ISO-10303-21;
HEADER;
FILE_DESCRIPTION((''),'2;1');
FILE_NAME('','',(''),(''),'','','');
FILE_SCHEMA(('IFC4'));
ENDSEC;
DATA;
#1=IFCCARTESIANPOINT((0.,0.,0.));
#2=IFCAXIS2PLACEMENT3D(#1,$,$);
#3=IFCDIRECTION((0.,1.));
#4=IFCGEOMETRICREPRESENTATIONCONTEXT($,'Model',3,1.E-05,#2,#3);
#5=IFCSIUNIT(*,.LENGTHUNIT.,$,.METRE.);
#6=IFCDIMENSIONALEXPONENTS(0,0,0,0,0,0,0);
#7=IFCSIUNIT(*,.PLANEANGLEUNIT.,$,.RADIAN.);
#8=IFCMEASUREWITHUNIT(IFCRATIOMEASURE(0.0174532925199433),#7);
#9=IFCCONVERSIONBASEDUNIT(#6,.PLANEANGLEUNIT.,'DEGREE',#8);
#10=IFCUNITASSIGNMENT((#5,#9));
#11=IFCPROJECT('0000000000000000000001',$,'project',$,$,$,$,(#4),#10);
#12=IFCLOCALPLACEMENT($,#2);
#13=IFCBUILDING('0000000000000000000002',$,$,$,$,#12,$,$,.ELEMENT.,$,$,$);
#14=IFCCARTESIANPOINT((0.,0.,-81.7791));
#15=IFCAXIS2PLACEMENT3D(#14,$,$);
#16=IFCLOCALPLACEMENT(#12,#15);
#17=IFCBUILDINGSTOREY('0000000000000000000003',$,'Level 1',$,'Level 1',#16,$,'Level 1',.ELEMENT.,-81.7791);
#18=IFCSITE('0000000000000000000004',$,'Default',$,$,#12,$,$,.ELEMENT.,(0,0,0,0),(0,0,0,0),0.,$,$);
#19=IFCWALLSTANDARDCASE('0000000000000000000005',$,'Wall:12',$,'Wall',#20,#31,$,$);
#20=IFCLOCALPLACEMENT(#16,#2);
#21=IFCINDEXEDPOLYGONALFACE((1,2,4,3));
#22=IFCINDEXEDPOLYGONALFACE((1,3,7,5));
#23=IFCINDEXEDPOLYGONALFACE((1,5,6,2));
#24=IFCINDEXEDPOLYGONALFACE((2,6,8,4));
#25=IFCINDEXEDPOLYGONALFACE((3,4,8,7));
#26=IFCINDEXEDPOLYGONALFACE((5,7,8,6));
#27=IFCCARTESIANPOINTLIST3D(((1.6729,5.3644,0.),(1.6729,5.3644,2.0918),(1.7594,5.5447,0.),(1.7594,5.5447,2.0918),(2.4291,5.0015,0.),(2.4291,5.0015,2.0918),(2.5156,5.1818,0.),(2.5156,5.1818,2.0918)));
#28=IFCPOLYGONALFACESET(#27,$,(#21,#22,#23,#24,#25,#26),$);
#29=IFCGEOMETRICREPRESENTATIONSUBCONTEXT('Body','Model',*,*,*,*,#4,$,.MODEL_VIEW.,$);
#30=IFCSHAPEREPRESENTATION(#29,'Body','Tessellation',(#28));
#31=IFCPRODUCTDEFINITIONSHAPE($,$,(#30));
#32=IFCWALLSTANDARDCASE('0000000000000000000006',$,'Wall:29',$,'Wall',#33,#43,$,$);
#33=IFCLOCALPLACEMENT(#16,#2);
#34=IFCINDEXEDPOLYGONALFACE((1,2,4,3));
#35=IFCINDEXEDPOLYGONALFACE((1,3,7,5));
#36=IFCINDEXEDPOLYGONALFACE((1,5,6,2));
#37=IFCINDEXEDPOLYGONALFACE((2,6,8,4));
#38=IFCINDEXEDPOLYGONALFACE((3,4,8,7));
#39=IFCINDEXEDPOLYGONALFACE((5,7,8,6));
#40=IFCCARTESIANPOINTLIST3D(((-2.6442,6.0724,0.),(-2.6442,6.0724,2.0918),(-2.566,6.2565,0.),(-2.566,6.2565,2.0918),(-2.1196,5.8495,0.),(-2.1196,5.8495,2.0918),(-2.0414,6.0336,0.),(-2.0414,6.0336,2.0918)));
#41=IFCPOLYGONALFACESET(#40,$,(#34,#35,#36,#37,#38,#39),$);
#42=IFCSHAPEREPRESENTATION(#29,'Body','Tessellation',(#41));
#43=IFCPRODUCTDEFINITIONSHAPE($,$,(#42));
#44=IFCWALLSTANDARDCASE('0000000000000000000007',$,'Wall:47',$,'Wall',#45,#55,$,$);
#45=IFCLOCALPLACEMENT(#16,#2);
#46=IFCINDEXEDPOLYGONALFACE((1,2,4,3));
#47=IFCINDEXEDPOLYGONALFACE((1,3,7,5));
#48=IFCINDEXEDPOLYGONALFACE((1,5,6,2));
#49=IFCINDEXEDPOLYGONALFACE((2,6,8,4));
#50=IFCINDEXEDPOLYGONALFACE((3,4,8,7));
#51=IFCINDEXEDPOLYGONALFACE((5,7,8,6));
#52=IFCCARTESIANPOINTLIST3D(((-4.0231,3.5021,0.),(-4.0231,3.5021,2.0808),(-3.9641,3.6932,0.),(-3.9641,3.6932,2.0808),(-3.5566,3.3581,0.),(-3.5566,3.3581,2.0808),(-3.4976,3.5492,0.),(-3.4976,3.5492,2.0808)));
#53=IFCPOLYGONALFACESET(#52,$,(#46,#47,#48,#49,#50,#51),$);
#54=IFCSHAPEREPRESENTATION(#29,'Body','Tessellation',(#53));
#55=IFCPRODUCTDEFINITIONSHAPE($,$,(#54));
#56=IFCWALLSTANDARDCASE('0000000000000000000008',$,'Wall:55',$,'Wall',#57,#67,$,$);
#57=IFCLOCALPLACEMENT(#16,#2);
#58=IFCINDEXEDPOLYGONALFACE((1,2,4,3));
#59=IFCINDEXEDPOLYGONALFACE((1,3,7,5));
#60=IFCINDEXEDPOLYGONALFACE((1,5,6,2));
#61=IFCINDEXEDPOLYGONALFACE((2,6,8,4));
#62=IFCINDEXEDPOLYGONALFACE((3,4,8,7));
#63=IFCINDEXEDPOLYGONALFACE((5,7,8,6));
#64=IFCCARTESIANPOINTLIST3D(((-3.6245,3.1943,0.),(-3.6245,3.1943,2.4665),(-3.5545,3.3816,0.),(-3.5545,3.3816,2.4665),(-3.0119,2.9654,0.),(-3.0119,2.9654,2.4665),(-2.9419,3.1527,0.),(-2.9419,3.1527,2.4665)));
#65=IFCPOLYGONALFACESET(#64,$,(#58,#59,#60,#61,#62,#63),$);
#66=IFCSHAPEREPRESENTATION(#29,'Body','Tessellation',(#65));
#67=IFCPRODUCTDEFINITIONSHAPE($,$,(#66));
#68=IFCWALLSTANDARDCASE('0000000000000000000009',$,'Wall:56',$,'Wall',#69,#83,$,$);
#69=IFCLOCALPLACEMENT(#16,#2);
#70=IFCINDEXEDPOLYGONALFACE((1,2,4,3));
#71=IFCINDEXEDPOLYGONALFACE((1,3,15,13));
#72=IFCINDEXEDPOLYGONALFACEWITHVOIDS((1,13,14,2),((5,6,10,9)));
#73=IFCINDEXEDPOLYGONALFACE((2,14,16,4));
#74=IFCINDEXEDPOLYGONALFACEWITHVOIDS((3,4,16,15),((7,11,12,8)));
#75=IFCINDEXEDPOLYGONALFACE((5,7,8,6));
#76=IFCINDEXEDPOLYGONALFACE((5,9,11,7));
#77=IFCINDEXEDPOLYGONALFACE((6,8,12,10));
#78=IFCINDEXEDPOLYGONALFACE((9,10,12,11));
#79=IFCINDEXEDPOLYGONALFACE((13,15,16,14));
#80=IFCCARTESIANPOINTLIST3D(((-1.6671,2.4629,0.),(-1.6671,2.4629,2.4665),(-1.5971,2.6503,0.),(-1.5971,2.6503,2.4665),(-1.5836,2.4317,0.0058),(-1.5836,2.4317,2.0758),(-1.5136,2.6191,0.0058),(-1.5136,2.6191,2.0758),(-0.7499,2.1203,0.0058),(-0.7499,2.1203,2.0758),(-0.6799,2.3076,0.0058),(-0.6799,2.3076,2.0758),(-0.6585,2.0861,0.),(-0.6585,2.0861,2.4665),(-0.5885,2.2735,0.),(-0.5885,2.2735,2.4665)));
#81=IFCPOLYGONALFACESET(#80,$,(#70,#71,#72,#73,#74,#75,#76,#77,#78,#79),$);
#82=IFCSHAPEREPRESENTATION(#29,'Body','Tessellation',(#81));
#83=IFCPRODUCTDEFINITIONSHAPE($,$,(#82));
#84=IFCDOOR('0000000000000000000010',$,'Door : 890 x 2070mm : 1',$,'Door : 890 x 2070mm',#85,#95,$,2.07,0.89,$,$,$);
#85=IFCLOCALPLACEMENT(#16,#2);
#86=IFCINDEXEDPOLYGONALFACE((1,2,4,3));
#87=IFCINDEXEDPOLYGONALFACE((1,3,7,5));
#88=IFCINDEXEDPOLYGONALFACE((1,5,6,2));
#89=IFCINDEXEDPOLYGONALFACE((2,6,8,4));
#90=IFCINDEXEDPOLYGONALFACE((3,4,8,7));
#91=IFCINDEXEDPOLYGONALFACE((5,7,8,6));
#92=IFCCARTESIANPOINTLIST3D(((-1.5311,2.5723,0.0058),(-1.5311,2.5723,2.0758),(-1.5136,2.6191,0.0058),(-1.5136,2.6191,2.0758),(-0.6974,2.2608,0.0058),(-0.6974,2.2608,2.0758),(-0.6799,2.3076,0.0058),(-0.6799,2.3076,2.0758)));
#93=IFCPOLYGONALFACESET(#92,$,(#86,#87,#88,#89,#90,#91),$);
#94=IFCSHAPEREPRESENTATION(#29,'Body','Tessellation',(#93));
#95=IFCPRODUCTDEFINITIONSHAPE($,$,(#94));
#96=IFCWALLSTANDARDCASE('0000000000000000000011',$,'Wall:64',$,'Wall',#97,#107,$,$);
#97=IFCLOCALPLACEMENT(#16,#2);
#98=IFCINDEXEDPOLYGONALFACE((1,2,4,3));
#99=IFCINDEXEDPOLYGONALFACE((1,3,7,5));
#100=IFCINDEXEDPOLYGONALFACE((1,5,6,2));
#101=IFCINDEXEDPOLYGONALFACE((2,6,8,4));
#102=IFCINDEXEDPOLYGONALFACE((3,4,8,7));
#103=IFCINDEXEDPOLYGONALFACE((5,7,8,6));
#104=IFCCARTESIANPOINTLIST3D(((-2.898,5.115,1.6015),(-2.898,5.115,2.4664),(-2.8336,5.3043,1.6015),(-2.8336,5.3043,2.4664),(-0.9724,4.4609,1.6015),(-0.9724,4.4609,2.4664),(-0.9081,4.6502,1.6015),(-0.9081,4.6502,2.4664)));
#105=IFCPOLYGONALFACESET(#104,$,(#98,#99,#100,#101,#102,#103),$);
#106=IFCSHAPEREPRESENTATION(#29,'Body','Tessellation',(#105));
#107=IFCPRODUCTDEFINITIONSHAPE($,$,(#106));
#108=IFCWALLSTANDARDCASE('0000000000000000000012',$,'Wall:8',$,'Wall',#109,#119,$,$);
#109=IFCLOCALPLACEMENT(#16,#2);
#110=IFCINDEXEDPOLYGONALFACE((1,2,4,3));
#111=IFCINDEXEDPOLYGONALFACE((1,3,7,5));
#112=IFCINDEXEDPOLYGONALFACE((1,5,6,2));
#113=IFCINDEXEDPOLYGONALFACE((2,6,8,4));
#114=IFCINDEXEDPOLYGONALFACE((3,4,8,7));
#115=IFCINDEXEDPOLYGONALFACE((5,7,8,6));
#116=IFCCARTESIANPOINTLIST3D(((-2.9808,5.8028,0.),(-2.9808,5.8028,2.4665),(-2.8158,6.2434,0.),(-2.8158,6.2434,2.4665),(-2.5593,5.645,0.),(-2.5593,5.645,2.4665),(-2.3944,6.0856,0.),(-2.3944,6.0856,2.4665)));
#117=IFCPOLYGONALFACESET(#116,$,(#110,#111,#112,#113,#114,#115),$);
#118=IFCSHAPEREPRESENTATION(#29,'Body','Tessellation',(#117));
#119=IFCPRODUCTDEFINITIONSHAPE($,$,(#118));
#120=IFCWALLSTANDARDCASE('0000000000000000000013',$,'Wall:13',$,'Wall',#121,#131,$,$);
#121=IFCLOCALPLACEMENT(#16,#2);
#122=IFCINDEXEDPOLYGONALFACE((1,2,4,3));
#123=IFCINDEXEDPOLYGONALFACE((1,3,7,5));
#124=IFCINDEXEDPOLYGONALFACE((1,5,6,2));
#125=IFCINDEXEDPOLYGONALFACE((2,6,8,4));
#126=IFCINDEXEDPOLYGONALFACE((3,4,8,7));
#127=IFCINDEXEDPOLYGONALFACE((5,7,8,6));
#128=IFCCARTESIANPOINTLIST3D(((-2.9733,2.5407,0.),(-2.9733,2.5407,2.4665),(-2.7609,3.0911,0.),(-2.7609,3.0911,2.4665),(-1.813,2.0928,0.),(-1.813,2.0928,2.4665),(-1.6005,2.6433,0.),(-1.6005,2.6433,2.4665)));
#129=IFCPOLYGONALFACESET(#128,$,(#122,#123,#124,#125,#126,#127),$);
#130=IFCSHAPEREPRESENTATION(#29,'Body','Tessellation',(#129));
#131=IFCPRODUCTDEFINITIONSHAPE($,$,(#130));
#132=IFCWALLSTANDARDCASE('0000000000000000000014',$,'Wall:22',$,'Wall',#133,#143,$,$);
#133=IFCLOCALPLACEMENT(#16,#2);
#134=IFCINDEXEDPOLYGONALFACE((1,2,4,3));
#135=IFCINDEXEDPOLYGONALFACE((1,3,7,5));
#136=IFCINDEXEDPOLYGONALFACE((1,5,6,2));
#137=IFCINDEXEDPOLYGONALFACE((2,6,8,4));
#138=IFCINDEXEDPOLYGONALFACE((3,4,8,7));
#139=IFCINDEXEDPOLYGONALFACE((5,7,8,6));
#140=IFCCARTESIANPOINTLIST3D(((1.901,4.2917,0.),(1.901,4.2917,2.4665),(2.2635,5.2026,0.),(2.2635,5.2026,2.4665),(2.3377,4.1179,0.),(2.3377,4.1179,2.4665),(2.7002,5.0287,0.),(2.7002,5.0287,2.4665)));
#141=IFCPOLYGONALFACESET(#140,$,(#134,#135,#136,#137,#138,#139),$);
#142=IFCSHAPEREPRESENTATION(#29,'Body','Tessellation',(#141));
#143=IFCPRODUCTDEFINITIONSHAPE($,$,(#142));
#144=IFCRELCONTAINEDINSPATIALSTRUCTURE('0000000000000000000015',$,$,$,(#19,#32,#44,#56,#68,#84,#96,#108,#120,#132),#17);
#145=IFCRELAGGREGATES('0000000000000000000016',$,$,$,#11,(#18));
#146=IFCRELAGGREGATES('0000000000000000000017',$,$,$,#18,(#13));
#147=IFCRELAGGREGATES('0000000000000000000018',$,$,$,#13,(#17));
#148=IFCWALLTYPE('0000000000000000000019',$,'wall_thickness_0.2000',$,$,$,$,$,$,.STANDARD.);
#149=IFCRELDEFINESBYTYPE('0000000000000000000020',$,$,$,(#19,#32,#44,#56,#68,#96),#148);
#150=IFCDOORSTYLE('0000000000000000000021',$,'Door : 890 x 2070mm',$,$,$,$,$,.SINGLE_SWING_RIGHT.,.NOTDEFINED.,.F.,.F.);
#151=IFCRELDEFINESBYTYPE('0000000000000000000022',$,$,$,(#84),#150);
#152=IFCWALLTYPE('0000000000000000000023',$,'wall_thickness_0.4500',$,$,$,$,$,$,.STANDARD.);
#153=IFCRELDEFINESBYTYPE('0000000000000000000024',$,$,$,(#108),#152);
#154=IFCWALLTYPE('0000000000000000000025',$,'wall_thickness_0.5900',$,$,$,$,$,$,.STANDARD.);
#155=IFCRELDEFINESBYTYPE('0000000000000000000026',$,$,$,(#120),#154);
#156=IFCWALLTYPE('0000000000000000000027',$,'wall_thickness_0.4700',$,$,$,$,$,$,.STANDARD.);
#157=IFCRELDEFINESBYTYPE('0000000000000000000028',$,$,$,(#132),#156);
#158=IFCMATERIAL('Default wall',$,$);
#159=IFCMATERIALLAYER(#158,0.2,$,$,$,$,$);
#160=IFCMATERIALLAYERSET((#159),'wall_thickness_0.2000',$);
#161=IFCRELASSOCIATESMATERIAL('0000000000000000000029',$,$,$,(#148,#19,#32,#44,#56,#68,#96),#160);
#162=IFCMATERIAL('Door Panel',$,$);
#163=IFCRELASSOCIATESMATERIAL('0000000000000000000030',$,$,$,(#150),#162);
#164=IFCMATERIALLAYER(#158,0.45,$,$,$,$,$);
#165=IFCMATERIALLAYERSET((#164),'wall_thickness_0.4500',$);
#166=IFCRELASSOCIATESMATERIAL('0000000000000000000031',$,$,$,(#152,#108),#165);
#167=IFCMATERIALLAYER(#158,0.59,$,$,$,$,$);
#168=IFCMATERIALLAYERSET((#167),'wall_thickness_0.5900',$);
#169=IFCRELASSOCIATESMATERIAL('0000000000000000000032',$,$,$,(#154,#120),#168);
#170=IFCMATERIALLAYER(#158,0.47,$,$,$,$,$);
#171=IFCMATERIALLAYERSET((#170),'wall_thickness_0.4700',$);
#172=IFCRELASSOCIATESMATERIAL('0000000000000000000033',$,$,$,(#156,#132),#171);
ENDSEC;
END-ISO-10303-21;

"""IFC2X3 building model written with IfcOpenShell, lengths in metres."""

from ifc_helpers import new_model, entity, si_unit, converted_unit, direction, frame, frame_2d, origin, origin_2d_with_axis, place, context, subcontext, project, spatial, polyline, rectangle, outline, extrude, source, transform, mapped, material, layer, layer_set, layer_usage, type_object, type_shapes, element, fill, save


model = new_model("IFC2X3")

# Units and contexts
model_context = context("Model", 3, precision=1e-05, world=origin(), true_north=direction((0.0, 1.0)))
body_context = subcontext(model_context, "Body", "Model", "MODEL_VIEW")
ifc_project = project(units=[si_unit("LENGTHUNIT", "METRE"), converted_unit("PLANEANGLEUNIT", "DEGREE", entity("IfcRatioMeasure", 0.0174532925199433), si_unit("PLANEANGLEUNIT", "RADIAN"), dimensions=[0, 0, 0, 0, 0, 0, 0])], contexts=[model_context])

# Site, building, storey
placement_1 = place(None, origin())
site = spatial("IfcSite", under=ifc_project, at=placement_1, Name="Default", CompositionType="ELEMENT", RefLatitude=(0, 0, 0, 0), RefLongitude=(0, 0, 0, 0), RefElevation=0.0)
building = spatial("IfcBuilding", under=site, at=placement_1, CompositionType="ELEMENT")
storey_placement = place(placement_1, frame((0.0, 0.0, -81.7791)))
storey = spatial("IfcBuildingStorey", under=building, at=storey_placement, Name="Level 1", ObjectType="Level 1", LongName="Level 1", CompositionType="ELEMENT", Elevation=-81.7791)

# Walls
ifc_material_1 = material(Name="Default wall")
ifc_layer_1 = layer(ifc_material_1, 0.2)
ifc_layer_set_1 = layer_set([ifc_layer_1], Name="wall_thickness_0.2000")
ifc_layer_usage_1 = layer_usage(ifc_layer_set_1, "AXIS2", "POSITIVE", -0.1)
wall_type_1 = type_object("IfcWallType", Name="wall_thickness_0.2000", PredefinedType="STANDARD", material=ifc_layer_set_1)
wall_1_placement = place(storey_placement, frame((1.7162, 5.4546, 0.0), z_axis=(0.0, 0.0, 1.0), x_axis=(0.901567, -0.43264, 0.0)))
element("IfcWallStandardCase", 1, at=wall_1_placement, inside=storey, type_object=wall_type_1, material=ifc_layer_usage_1, Name="Wall:12", ObjectType="Wall", context=body_context, shape_type="SweptSolid", body=[
    extrude(outline(polyline([(0.8387, -0.1), (0.8387, 0.1), (0.0, 0.1), (0.0, -0.1), (0.8387, -0.1)])), origin(), (0.0, 0.0, 1.0), 2.0918),
])
wall_2_placement = place(storey_placement, frame((-2.6051, 6.1645, 0.0), z_axis=(0.0, 0.0, 1.0), x_axis=(0.920349, -0.391098, 0.0)))
element("IfcWallStandardCase", 2, at=wall_2_placement, inside=storey, type_object=wall_type_1, material=ifc_layer_usage_1, Name="Wall:29", ObjectType="Wall", context=body_context, shape_type="SweptSolid", body=[
    extrude(outline(polyline([(0.57, -0.1), (0.57, 0.1), (0.0, 0.1), (0.0, -0.1), (0.57, -0.1)])), origin(), (0.0, 0.0, 1.0), 2.0918),
])
wall_3_placement = place(storey_placement, frame((-3.9936, 3.5976, 0.0), z_axis=(0.0, 0.0, 1.0), x_axis=(0.955528, -0.2949, 0.0)))
element("IfcWallStandardCase", 3, at=wall_3_placement, inside=storey, type_object=wall_type_1, material=ifc_layer_usage_1, Name="Wall:47", ObjectType="Wall", context=body_context, shape_type="SweptSolid", body=[
    extrude(outline(polyline([(0.4882, -0.1), (0.4882, 0.1), (0.0, 0.1), (0.0, -0.1), (0.4882, -0.1)])), origin(), (0.0, 0.0, 1.0), 2.0808),
])
wall_4_placement = place(storey_placement, frame((-3.5895, 3.2879, 0.0), z_axis=(0.0, 0.0, 1.0), x_axis=(0.936753, -0.349992, 0.0)))
element("IfcWallStandardCase", 4, at=wall_4_placement, inside=storey, type_object=wall_type_1, material=ifc_layer_usage_1, Name="Wall:55", ObjectType="Wall", context=body_context, shape_type="SweptSolid", body=[
    extrude(outline(polyline([(0.654, -0.1), (0.654, 0.1), (0.0, 0.1), (0.0, -0.1), (0.654, -0.1)])), origin(), (0.0, 0.0, 1.0), 2.4665),
])

# Wall, opening, door
wall_5_placement = place(storey_placement, frame((-1.6321, 2.5566, 0.0), z_axis=(0.0, 0.0, 1.0), x_axis=(0.936753, -0.349992, 0.0)))
wall_5 = element("IfcWallStandardCase", 5, at=wall_5_placement, inside=storey, type_object=wall_type_1, material=ifc_layer_usage_1, Name="Wall:56", ObjectType="Wall", context=body_context, shape_type="SweptSolid", body=[
    extrude(outline(polyline([(1.0767, -0.1), (1.0767, 0.1), (0.0, 0.1), (0.0, -0.1), (1.0767, -0.1)])), origin(), (0.0, 0.0, 1.0), 2.4665),
])
opening_1_placement = place(wall_5_placement, frame((0.0891, -0.1, 0.0058)))
opening_1 = element("IfcOpeningElement", 6, at=opening_1_placement, cuts=wall_5, ObjectType="Opening", context=body_context, shape_type="SweptSolid", body=[
    extrude(rectangle(XDim=0.89, YDim=2.07, at=frame_2d((1.035, 0.445), x_axis=(0.0, 1.0))), frame((0.0, 0.0, 0.0), z_axis=(0.0, 1.0, 0.0), x_axis=(0.0, 0.0, 1.0)), (0.0, 0.0, 1.0), 0.2),
])
ifc_material_2 = material(Name="Door Panel")
door_style_1 = type_object("IfcDoorStyle", Name="Door : 890 x 2070mm", ConstructionType="NOTDEFINED", OperationType="SINGLE_SWING_RIGHT", ParameterTakesPrecedence=False, Sizeable=False, material=ifc_material_2)
shared_shape_1 = source(origin(), body_context, "Body", "SweptSolid", [
    extrude(rectangle(XDim=0.05, YDim=0.89, at=origin_2d_with_axis()), frame((0.445, 0.175, 0.0), z_axis=(0.0, 0.0, 1.0), x_axis=(0.0, 1.0, 0.0)), (0.0, 0.0, 1.0), 2.07),
])
type_shapes(door_style_1, [shared_shape_1])
door_1_placement = place(opening_1_placement, origin())
door_1 = element("IfcDoor", 7, at=door_1_placement, inside=storey, type_object=door_style_1, Name="Door : 890 x 2070mm : 1", ObjectType="Door : 890 x 2070mm", OverallHeight=2.07, OverallWidth=0.89, context=body_context, shape_type="MappedRepresentation", body=[
    mapped(shared_shape_1, transform((0.0, 0.0, 0.0), scale=1.0)),
])
fill(opening_1, door_1)

# Walls
placement_2 = place(placement_1, frame((0.0, 0.0, -80.1776)))
wall_6_placement = place(placement_2, frame((-2.8658, 5.2097, 0.0), z_axis=(0.0, 0.0, 1.0), x_axis=(0.946857, -0.321656, 0.0)))
element("IfcWallStandardCase", 8, at=wall_6_placement, inside=storey, type_object=wall_type_1, material=ifc_layer_usage_1, Name="Wall:64", ObjectType="Wall", context=body_context, shape_type="SweptSolid", body=[
    extrude(outline(polyline([(2.0336, -0.1), (2.0336, 0.1), (0.0, 0.1), (0.0, -0.1), (2.0336, -0.1)])), origin(), (0.0, 0.0, 1.0), 0.8649),
])
ifc_layer_2 = layer(ifc_material_1, 0.45)
ifc_layer_set_2 = layer_set([ifc_layer_2], Name="wall_thickness_0.4500")
ifc_layer_usage_2 = layer_usage(ifc_layer_set_2, "AXIS2", "POSITIVE", -0.225)
wall_type_2 = type_object("IfcWallType", Name="wall_thickness_0.4500", PredefinedType="STANDARD", material=ifc_layer_set_2)
wall_7_placement = place(storey_placement, frame((-2.6051, 6.1645, 0.0), z_axis=(0.0, 0.0, 1.0), x_axis=(-0.350587, -0.93653, 0.0)))
element("IfcWallStandardCase", 9, at=wall_7_placement, inside=storey, type_object=wall_type_2, material=ifc_layer_usage_2, Name="Wall:8", ObjectType="Wall", context=body_context, shape_type="SweptSolid", body=[
    extrude(outline(polyline([(0.4704, -0.225), (0.4704, 0.225), (0.0, 0.225), (0.0, -0.225), (0.4704, -0.225)])), origin(), (0.0, 0.0, 1.0), 2.4665),
])
ifc_layer_3 = layer(ifc_material_1, 0.59)
ifc_layer_set_3 = layer_set([ifc_layer_3], Name="wall_thickness_0.5900")
ifc_layer_usage_3 = layer_usage(ifc_layer_set_3, "AXIS2", "POSITIVE", -0.295)
wall_type_3 = type_object("IfcWallType", Name="wall_thickness_0.5900", PredefinedType="STANDARD", material=ifc_layer_set_3)
wall_8_placement = place(storey_placement, frame((-2.8671, 2.8159, 0.0), z_axis=(0.0, 0.0, 1.0), x_axis=(0.93292, -0.360083, 0.0)))
element("IfcWallStandardCase", 10, at=wall_8_placement, inside=storey, type_object=wall_type_3, material=ifc_layer_usage_3, Name="Wall:13", ObjectType="Wall", context=body_context, shape_type="SweptSolid", body=[
    extrude(outline(polyline([(1.2438, -0.295), (1.2438, 0.295), (0.0, 0.295), (0.0, -0.295), (1.2438, -0.295)])), origin(), (0.0, 0.0, 1.0), 2.4665),
])
ifc_layer_4 = layer(ifc_material_1, 0.47)
ifc_layer_set_4 = layer_set([ifc_layer_4], Name="wall_thickness_0.4700")
ifc_layer_usage_4 = layer_usage(ifc_layer_set_4, "AXIS2", "POSITIVE", -0.235)
wall_type_4 = type_object("IfcWallType", Name="wall_thickness_0.4700", PredefinedType="STANDARD", material=ifc_layer_set_4)
wall_9_placement = place(storey_placement, frame((2.4819, 5.1156, 0.0), z_axis=(0.0, 0.0, 1.0), x_axis=(-0.36982, -0.929103, 0.0)))
element("IfcWallStandardCase", 11, at=wall_9_placement, inside=storey, type_object=wall_type_4, material=ifc_layer_usage_4, Name="Wall:22", ObjectType="Wall", context=body_context, shape_type="SweptSolid", body=[
    extrude(outline(polyline([(0.9803, -0.235), (0.9803, 0.235), (0.0, 0.235), (0.0, -0.235), (0.9803, -0.235)])), origin(), (0.0, 0.0, 1.0), 2.4665),
])

save(model, "model.ifc")
